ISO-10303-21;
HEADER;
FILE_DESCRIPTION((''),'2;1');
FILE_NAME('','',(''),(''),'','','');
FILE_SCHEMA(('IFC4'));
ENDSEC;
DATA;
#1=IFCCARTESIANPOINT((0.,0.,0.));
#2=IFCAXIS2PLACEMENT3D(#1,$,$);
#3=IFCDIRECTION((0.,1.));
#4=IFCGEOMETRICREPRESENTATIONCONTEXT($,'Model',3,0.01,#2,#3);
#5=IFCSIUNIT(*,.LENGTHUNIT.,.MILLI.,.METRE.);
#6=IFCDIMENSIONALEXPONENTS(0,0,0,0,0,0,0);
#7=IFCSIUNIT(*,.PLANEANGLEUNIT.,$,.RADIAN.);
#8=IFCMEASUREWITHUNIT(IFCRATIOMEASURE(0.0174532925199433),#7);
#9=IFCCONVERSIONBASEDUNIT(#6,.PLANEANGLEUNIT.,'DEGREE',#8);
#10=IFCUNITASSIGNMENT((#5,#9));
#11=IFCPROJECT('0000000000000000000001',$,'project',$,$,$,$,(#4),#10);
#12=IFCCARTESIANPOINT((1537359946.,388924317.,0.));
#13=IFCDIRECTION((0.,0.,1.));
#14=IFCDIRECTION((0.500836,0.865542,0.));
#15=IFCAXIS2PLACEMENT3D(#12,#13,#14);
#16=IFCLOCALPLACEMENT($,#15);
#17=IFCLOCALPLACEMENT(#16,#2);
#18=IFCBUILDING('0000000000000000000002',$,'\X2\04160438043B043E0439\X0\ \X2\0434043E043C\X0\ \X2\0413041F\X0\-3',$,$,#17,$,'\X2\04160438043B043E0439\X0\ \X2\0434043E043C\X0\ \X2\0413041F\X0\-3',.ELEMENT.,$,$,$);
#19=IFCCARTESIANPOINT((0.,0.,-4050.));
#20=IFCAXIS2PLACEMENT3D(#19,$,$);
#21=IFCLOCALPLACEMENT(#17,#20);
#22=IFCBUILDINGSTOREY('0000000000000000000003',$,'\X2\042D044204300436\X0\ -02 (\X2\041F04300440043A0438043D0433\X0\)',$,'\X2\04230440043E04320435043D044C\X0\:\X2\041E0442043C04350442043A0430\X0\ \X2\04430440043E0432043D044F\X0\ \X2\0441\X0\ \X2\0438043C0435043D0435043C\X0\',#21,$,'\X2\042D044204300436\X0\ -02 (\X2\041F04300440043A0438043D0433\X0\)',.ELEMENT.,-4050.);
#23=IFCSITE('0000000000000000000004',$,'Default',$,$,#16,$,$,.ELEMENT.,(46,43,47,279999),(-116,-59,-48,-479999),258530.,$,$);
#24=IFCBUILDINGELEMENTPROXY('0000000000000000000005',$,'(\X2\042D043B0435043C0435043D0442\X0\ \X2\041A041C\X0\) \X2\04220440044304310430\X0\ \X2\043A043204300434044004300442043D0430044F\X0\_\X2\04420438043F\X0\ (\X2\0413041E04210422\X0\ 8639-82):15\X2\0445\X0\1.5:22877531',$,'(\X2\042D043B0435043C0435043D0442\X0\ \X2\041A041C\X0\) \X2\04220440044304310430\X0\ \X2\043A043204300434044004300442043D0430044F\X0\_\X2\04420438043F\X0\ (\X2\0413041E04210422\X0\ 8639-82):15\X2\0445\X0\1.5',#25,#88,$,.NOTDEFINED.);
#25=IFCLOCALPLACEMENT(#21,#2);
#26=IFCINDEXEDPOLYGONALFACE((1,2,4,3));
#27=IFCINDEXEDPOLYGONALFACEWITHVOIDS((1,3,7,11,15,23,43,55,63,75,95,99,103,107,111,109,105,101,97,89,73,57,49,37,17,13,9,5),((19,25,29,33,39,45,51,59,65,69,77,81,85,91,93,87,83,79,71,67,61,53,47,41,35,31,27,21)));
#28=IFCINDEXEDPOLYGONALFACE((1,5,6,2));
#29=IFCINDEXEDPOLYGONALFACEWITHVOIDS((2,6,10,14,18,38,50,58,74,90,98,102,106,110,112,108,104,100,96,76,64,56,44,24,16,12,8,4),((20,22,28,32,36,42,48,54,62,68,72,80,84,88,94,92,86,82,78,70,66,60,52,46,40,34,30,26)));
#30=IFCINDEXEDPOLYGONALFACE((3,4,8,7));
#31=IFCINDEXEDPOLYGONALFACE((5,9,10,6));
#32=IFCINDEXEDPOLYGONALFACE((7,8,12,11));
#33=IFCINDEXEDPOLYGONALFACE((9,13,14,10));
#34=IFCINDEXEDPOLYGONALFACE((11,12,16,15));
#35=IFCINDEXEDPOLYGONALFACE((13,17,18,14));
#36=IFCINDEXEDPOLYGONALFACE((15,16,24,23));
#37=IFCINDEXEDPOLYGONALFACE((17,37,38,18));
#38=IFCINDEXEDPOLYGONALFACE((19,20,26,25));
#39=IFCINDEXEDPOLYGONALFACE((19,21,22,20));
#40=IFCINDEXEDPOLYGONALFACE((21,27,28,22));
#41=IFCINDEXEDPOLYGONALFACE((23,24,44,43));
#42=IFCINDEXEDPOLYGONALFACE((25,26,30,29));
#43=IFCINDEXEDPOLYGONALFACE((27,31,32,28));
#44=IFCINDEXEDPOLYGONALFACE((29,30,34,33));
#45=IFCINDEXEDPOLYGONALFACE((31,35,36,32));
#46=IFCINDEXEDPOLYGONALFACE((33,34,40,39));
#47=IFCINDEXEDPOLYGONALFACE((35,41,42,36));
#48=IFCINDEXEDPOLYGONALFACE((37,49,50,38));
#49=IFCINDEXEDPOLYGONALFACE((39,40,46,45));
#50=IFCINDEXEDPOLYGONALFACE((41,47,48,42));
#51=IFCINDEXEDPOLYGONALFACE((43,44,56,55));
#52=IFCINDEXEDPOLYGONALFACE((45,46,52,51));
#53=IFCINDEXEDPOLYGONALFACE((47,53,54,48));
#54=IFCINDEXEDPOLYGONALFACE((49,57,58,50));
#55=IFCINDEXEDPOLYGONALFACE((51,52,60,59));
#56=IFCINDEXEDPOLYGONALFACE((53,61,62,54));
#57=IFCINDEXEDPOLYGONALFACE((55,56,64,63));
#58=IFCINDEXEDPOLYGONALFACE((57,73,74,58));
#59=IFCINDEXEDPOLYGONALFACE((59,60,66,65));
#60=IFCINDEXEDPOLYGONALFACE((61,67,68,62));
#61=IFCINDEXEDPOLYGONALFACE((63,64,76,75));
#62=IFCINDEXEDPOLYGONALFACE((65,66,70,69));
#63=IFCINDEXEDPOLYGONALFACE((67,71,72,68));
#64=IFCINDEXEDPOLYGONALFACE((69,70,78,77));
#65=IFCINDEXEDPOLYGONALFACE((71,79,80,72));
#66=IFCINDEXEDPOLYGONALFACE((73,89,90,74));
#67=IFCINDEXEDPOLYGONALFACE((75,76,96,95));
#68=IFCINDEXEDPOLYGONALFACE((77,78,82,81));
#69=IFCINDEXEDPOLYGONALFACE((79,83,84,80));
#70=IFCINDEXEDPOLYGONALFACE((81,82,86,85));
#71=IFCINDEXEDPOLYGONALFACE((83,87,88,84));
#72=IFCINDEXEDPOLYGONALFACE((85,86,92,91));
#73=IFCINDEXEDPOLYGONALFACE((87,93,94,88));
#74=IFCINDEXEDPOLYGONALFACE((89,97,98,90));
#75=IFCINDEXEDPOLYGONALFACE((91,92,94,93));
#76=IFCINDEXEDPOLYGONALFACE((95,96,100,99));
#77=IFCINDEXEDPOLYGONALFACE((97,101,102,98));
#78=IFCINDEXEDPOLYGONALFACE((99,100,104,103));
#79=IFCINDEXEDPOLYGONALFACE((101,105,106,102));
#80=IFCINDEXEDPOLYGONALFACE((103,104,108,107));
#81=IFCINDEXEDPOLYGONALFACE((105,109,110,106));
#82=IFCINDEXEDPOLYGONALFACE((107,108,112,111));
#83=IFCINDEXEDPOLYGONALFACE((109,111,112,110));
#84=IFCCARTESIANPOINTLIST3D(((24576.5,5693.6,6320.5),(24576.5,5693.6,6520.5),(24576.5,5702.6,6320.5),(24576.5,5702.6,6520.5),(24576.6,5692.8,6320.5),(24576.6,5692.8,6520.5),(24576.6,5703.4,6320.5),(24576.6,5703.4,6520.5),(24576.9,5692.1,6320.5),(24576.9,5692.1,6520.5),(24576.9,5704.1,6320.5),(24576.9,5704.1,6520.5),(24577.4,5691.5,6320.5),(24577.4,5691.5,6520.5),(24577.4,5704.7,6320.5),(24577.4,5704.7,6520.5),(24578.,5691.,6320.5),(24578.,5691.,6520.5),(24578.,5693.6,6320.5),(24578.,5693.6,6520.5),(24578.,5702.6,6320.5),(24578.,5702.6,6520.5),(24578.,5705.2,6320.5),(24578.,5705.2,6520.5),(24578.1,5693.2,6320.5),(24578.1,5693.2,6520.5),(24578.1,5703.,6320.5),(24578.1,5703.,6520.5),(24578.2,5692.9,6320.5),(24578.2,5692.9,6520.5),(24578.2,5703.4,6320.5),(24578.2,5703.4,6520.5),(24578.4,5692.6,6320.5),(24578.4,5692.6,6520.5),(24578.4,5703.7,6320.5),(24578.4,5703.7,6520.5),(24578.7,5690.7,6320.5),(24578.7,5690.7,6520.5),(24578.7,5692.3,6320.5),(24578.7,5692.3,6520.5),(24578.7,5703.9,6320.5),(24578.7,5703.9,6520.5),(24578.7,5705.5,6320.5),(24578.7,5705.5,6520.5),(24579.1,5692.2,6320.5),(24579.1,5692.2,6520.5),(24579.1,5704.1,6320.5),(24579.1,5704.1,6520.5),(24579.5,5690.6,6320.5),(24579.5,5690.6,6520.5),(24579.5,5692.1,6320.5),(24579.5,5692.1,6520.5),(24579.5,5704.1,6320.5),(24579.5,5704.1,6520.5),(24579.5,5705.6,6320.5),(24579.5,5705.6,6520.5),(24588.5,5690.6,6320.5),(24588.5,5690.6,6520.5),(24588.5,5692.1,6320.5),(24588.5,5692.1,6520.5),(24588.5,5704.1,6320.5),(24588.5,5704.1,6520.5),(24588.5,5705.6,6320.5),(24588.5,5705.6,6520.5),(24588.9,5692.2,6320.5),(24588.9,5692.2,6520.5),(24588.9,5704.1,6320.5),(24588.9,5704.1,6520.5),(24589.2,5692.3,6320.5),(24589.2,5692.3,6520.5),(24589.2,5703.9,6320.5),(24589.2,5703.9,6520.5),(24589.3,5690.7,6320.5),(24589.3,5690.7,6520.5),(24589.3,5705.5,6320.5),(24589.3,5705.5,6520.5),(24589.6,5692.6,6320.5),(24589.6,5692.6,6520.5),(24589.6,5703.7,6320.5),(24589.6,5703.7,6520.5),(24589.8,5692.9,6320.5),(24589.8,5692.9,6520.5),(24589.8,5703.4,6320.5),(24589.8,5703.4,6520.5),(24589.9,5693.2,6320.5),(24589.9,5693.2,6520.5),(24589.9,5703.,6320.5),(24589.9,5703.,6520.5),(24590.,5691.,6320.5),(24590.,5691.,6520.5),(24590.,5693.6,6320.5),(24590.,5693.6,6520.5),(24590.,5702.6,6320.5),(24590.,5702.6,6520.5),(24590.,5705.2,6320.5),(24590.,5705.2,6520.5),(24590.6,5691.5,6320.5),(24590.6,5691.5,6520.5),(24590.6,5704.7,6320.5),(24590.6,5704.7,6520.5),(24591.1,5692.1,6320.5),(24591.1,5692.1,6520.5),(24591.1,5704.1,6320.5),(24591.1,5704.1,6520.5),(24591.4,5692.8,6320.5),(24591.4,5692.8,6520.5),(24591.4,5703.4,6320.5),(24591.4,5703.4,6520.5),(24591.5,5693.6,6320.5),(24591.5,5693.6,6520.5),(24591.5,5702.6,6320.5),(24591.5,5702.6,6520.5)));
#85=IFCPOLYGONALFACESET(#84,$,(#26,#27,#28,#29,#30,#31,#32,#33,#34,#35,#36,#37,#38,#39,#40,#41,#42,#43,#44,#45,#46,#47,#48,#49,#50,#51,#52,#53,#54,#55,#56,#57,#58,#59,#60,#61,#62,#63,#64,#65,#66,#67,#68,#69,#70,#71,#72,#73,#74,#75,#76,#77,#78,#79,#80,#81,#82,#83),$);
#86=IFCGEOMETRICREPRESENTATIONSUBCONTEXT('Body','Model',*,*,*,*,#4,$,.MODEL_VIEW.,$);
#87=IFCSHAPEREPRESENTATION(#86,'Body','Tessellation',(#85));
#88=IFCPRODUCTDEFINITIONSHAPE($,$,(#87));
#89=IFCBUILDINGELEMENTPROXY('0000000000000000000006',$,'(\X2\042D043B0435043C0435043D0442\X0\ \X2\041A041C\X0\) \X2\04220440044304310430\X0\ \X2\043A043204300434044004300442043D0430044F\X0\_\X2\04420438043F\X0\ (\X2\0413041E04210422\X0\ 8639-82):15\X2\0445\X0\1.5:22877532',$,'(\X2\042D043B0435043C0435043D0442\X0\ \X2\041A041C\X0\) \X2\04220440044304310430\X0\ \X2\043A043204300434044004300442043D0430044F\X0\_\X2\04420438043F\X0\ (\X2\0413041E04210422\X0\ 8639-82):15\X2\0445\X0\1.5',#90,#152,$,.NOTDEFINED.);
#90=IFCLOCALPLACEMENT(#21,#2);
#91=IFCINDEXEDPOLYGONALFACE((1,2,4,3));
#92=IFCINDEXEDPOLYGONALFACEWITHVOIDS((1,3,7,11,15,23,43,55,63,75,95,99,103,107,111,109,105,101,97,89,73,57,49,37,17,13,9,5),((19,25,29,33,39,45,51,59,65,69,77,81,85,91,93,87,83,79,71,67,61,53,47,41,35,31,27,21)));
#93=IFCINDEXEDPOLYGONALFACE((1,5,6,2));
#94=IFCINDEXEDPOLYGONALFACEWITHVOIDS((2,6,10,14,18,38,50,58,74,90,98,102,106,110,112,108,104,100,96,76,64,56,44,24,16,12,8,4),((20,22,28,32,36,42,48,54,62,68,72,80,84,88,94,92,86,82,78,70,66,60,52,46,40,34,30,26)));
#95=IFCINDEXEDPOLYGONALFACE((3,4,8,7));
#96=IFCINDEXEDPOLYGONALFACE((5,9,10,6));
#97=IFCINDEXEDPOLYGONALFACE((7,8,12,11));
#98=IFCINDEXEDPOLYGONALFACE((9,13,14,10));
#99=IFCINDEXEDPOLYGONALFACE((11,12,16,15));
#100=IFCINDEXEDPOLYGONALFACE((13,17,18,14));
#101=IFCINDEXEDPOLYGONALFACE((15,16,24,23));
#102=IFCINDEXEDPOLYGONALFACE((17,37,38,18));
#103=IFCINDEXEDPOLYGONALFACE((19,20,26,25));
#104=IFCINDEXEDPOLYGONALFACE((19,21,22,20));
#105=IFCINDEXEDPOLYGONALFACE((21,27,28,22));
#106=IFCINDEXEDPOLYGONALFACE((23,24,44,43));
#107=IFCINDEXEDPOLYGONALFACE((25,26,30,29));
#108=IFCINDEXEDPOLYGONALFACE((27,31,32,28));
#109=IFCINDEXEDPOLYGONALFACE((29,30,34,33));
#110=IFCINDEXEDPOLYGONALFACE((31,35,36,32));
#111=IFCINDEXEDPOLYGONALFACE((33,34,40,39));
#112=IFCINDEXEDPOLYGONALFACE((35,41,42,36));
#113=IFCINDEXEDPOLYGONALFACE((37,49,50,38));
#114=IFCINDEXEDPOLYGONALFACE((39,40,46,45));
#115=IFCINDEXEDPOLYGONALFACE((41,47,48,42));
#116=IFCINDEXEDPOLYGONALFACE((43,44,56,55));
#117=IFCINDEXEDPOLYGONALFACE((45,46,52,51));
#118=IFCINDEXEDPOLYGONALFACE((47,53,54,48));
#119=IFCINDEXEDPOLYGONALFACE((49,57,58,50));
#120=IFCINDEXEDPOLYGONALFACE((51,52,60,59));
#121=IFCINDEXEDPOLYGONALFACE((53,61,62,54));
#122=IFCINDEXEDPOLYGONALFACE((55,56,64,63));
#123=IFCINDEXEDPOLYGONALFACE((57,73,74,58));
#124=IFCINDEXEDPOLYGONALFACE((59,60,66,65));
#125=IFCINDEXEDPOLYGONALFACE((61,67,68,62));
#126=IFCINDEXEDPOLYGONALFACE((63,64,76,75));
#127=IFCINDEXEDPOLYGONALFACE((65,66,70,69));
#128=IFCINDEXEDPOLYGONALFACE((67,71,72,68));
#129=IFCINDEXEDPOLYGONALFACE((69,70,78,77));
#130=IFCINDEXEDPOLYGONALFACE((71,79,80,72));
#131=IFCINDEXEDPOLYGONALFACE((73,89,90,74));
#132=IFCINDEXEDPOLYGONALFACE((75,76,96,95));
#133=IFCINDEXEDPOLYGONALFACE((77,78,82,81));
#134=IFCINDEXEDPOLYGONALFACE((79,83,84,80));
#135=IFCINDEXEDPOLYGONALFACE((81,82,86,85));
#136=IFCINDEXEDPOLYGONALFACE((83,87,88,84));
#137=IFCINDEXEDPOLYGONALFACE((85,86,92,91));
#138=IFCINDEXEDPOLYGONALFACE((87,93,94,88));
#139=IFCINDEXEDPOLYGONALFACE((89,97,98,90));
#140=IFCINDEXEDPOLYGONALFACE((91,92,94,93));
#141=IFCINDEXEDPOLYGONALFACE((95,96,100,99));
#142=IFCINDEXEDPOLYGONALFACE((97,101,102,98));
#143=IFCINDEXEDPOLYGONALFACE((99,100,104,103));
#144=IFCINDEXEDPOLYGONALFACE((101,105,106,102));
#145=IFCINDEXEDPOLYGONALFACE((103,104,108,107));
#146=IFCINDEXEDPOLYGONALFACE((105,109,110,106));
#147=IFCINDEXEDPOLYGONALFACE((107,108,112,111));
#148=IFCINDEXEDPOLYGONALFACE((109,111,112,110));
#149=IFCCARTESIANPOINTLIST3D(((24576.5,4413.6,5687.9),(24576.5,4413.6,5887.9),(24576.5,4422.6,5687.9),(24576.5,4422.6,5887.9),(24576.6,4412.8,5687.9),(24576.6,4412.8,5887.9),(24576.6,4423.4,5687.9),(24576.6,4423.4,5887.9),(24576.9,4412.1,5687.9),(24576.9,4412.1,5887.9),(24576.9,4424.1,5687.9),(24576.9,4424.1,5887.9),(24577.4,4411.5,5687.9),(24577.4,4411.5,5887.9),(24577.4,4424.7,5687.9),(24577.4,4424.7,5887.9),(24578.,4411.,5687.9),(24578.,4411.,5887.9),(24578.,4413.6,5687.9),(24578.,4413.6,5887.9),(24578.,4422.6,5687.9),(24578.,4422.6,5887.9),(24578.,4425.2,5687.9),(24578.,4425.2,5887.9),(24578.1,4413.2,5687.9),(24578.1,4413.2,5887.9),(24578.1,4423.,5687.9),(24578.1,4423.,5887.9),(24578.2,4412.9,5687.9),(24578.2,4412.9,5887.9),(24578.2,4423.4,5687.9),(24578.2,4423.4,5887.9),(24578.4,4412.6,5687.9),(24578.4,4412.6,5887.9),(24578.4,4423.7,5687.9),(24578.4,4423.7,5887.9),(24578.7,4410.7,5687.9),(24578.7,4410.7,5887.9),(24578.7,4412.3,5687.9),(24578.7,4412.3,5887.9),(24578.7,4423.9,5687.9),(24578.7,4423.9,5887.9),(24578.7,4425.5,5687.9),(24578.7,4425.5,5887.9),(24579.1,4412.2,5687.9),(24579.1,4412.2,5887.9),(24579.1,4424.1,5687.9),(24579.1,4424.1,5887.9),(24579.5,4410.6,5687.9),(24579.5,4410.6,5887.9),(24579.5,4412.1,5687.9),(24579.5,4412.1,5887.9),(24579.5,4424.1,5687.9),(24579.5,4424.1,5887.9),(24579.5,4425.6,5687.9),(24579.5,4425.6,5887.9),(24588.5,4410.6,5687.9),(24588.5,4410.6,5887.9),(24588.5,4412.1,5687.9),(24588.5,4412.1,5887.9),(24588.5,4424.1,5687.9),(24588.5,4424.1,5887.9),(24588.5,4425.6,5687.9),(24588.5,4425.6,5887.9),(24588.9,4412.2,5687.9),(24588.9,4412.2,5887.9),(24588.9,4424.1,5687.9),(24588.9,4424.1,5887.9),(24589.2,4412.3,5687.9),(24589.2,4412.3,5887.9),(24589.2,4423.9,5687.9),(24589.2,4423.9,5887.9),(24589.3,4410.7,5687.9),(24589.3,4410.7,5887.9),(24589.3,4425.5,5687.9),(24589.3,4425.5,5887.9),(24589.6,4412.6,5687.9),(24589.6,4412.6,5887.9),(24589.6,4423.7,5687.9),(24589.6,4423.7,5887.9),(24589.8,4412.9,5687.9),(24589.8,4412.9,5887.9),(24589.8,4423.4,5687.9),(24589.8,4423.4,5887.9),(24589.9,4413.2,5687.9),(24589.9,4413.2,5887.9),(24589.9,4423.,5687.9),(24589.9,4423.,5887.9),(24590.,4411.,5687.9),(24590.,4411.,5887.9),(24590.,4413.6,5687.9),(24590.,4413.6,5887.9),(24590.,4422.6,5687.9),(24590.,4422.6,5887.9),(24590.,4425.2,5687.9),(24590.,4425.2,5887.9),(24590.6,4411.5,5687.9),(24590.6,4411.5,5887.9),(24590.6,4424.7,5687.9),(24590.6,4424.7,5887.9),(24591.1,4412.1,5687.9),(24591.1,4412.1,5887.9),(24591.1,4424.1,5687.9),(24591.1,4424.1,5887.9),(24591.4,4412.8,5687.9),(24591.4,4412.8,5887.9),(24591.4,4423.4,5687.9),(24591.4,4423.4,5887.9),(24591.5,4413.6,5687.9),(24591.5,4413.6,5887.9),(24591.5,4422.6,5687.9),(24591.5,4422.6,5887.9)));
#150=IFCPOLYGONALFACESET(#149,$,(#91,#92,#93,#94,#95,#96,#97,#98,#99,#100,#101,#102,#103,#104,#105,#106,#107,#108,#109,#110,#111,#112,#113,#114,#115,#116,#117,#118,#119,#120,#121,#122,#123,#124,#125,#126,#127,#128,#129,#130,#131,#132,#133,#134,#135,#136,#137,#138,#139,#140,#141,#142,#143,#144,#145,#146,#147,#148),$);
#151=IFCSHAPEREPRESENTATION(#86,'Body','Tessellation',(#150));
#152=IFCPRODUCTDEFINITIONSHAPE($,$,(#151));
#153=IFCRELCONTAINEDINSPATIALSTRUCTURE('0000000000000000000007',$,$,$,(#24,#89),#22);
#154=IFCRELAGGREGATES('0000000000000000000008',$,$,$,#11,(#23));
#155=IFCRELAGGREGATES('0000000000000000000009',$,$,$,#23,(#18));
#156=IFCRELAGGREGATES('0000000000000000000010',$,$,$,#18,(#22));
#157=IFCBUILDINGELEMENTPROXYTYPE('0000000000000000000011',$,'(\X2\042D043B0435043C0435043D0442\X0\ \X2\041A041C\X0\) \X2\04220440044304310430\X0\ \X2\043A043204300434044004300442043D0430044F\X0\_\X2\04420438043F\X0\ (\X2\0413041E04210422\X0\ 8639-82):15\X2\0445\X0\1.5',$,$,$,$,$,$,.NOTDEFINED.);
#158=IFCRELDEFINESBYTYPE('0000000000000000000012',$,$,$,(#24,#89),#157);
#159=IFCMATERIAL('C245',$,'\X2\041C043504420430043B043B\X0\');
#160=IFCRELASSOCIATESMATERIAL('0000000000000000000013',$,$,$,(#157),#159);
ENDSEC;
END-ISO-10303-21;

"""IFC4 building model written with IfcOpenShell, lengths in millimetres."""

from ifc_helpers import new_model, entity, si_unit, converted_unit, direction, frame, frame_2d, origin, place, context, subcontext, project, spatial, polyline, circle_curve, parameter, trimmed, segment, composite_curve, outline, extrude, source, transform, mapped, material, type_object, type_shapes, element, save


model = new_model("IFC4")

# Units and contexts
model_context = context("Model", 3, precision=0.01, world=origin(), true_north=direction((0.0, 1.0)))
body_context = subcontext(model_context, "Body", "Model", "MODEL_VIEW")
ifc_project = project(units=[si_unit("LENGTHUNIT", "METRE", prefix="MILLI"), converted_unit("PLANEANGLEUNIT", "DEGREE", entity("IfcRatioMeasure", 0.0174532925199433), si_unit("PLANEANGLEUNIT", "RADIAN"), dimensions=[0, 0, 0, 0, 0, 0, 0])], contexts=[model_context])

# Site, building, storey
site_placement = place(None, frame((1537359946.0, 388924317.0, 0.0), z_axis=(0.0, 0.0, 1.0), x_axis=(0.500836, 0.865542, 0.0)))
site = spatial("IfcSite", under=ifc_project, at=site_placement, Name="Default", CompositionType="ELEMENT", RefLatitude=(46, 43, 47, 279999), RefLongitude=(-116, -59, -48, -479999), RefElevation=258530.0)
building_placement = place(site_placement, origin())
building = spatial("IfcBuilding", under=site, at=building_placement, Name="Жилой дом ГП-3", LongName="Жилой дом ГП-3", CompositionType="ELEMENT")
storey_placement = place(building_placement, frame((0.0, 0.0, -4050.0)))
storey = spatial("IfcBuildingStorey", under=building, at=storey_placement, Name="Этаж -02 (Паркинг)", ObjectType="Уровень:Отметка уровня с именем", LongName="Этаж -02 (Паркинг)", CompositionType="ELEMENT", Elevation=-4050.0)

# Building element proxies
ifc_material_1 = material(Name="C245", Category="Металл")
building_element_proxy_type_1 = type_object("IfcBuildingElementProxyType", Name="(Элемент КМ) Труба квадратная_тип (ГОСТ 8639-82):15х1.5", PredefinedType="NOTDEFINED", material=ifc_material_1)
shared_shape_1 = source(origin(), body_context, "Body", "SweptSolid", [
    extrude(outline(composite_curve([segment(trimmed(circle_curve(frame_2d((4.5, -4.5), x_axis=(1.0, 0.0)), 3.0), [parameter(270.0)], [parameter(0.0)], True, "PARAMETER"), True, "CONTINUOUS"), segment(polyline([(7.5, -4.5), (7.5, 4.5)]), True, "CONTINUOUS"), segment(trimmed(circle_curve(frame_2d((4.5, 4.5), x_axis=(1.0, 0.0)), 3.0), [parameter(0.0)], [parameter(90.0)], True, "PARAMETER"), True, "CONTINUOUS"), segment(polyline([(4.5, 7.5), (-4.5, 7.5)]), True, "CONTINUOUS"), segment(trimmed(circle_curve(frame_2d((-4.5, 4.5), x_axis=(1.0, 0.0)), 3.0), [parameter(90.0)], [parameter(180.0)], True, "PARAMETER"), True, "CONTINUOUS"), segment(polyline([(-7.5, 4.5), (-7.5, -4.5)]), True, "CONTINUOUS"), segment(trimmed(circle_curve(frame_2d((-4.5, -4.5), x_axis=(1.0, 0.0)), 3.0), [parameter(180.0)], [parameter(270.0)], True, "PARAMETER"), True, "CONTINUOUS"), segment(polyline([(-4.5, -7.5), (4.5, -7.5)]), True, "CONTINUOUS")], self_intersect=False), holes=[composite_curve([segment(polyline([(4.5, -6.0), (-4.5, -6.0)]), True, "CONTINUOUS"), segment(trimmed(circle_curve(frame_2d((-4.5, -4.5), x_axis=(1.0, 0.0)), 1.5), [parameter(180.0)], [parameter(270.0)], True, "PARAMETER"), False, "CONTINUOUS"), segment(polyline([(-6.0, -4.5), (-6.0, 4.5)]), True, "CONTINUOUS"), segment(trimmed(circle_curve(frame_2d((-4.5, 4.5), x_axis=(1.0, 0.0)), 1.5), [parameter(90.0)], [parameter(180.0)], True, "PARAMETER"), False, "CONTINUOUS"), segment(polyline([(-4.5, 6.0), (4.5, 6.0)]), True, "CONTINUOUS"), segment(trimmed(circle_curve(frame_2d((4.5, 4.5), x_axis=(1.0, 0.0)), 1.5), [parameter(0.0)], [parameter(90.0)], True, "PARAMETER"), False, "CONTINUOUS"), segment(polyline([(6.0, 4.5), (6.0, -4.5)]), True, "CONTINUOUS"), segment(trimmed(circle_curve(frame_2d((4.5, -4.5), x_axis=(1.0, 0.0)), 1.5), [parameter(270.0)], [parameter(0.0)], True, "PARAMETER"), False, "CONTINUOUS")], self_intersect=False)]), frame((-100.0, 0.0, 0.0), z_axis=(1.0, 0.0, 0.0), x_axis=(0.0, -1.0, 0.0)), (0.0, 0.0, 1.0), 200.0),
])
type_shapes(building_element_proxy_type_1, [shared_shape_1])
for number, where, z_axis, x_axis, name in (
    (1, (24584.0, 5698.1, 6420.5), (1.0, 0.0, 0.0), (0.0, 0.0, 1.0), "(Элемент КМ) Труба квадратная_тип (ГОСТ 8639-82):15х1.5:22877531"),
    (2, (24584.0, 4418.1, 5787.9), (1.0, 0.0, 0.0), (0.0, 0.0, 1.0), "(Элемент КМ) Труба квадратная_тип (ГОСТ 8639-82):15х1.5:22877532"),
):
    element("IfcBuildingElementProxy", number, at=place(storey_placement, frame(where, z_axis=z_axis, x_axis=x_axis)), inside=storey, type_object=building_element_proxy_type_1, Name=name, ObjectType="(Элемент КМ) Труба квадратная_тип (ГОСТ 8639-82):15х1.5", PredefinedType="NOTDEFINED", context=body_context, shape_type="MappedRepresentation", body=[
        mapped(shared_shape_1, transform((0.0, 0.0, 0.0), scale=1.0)),
    ])

save(model, "model.ifc")
